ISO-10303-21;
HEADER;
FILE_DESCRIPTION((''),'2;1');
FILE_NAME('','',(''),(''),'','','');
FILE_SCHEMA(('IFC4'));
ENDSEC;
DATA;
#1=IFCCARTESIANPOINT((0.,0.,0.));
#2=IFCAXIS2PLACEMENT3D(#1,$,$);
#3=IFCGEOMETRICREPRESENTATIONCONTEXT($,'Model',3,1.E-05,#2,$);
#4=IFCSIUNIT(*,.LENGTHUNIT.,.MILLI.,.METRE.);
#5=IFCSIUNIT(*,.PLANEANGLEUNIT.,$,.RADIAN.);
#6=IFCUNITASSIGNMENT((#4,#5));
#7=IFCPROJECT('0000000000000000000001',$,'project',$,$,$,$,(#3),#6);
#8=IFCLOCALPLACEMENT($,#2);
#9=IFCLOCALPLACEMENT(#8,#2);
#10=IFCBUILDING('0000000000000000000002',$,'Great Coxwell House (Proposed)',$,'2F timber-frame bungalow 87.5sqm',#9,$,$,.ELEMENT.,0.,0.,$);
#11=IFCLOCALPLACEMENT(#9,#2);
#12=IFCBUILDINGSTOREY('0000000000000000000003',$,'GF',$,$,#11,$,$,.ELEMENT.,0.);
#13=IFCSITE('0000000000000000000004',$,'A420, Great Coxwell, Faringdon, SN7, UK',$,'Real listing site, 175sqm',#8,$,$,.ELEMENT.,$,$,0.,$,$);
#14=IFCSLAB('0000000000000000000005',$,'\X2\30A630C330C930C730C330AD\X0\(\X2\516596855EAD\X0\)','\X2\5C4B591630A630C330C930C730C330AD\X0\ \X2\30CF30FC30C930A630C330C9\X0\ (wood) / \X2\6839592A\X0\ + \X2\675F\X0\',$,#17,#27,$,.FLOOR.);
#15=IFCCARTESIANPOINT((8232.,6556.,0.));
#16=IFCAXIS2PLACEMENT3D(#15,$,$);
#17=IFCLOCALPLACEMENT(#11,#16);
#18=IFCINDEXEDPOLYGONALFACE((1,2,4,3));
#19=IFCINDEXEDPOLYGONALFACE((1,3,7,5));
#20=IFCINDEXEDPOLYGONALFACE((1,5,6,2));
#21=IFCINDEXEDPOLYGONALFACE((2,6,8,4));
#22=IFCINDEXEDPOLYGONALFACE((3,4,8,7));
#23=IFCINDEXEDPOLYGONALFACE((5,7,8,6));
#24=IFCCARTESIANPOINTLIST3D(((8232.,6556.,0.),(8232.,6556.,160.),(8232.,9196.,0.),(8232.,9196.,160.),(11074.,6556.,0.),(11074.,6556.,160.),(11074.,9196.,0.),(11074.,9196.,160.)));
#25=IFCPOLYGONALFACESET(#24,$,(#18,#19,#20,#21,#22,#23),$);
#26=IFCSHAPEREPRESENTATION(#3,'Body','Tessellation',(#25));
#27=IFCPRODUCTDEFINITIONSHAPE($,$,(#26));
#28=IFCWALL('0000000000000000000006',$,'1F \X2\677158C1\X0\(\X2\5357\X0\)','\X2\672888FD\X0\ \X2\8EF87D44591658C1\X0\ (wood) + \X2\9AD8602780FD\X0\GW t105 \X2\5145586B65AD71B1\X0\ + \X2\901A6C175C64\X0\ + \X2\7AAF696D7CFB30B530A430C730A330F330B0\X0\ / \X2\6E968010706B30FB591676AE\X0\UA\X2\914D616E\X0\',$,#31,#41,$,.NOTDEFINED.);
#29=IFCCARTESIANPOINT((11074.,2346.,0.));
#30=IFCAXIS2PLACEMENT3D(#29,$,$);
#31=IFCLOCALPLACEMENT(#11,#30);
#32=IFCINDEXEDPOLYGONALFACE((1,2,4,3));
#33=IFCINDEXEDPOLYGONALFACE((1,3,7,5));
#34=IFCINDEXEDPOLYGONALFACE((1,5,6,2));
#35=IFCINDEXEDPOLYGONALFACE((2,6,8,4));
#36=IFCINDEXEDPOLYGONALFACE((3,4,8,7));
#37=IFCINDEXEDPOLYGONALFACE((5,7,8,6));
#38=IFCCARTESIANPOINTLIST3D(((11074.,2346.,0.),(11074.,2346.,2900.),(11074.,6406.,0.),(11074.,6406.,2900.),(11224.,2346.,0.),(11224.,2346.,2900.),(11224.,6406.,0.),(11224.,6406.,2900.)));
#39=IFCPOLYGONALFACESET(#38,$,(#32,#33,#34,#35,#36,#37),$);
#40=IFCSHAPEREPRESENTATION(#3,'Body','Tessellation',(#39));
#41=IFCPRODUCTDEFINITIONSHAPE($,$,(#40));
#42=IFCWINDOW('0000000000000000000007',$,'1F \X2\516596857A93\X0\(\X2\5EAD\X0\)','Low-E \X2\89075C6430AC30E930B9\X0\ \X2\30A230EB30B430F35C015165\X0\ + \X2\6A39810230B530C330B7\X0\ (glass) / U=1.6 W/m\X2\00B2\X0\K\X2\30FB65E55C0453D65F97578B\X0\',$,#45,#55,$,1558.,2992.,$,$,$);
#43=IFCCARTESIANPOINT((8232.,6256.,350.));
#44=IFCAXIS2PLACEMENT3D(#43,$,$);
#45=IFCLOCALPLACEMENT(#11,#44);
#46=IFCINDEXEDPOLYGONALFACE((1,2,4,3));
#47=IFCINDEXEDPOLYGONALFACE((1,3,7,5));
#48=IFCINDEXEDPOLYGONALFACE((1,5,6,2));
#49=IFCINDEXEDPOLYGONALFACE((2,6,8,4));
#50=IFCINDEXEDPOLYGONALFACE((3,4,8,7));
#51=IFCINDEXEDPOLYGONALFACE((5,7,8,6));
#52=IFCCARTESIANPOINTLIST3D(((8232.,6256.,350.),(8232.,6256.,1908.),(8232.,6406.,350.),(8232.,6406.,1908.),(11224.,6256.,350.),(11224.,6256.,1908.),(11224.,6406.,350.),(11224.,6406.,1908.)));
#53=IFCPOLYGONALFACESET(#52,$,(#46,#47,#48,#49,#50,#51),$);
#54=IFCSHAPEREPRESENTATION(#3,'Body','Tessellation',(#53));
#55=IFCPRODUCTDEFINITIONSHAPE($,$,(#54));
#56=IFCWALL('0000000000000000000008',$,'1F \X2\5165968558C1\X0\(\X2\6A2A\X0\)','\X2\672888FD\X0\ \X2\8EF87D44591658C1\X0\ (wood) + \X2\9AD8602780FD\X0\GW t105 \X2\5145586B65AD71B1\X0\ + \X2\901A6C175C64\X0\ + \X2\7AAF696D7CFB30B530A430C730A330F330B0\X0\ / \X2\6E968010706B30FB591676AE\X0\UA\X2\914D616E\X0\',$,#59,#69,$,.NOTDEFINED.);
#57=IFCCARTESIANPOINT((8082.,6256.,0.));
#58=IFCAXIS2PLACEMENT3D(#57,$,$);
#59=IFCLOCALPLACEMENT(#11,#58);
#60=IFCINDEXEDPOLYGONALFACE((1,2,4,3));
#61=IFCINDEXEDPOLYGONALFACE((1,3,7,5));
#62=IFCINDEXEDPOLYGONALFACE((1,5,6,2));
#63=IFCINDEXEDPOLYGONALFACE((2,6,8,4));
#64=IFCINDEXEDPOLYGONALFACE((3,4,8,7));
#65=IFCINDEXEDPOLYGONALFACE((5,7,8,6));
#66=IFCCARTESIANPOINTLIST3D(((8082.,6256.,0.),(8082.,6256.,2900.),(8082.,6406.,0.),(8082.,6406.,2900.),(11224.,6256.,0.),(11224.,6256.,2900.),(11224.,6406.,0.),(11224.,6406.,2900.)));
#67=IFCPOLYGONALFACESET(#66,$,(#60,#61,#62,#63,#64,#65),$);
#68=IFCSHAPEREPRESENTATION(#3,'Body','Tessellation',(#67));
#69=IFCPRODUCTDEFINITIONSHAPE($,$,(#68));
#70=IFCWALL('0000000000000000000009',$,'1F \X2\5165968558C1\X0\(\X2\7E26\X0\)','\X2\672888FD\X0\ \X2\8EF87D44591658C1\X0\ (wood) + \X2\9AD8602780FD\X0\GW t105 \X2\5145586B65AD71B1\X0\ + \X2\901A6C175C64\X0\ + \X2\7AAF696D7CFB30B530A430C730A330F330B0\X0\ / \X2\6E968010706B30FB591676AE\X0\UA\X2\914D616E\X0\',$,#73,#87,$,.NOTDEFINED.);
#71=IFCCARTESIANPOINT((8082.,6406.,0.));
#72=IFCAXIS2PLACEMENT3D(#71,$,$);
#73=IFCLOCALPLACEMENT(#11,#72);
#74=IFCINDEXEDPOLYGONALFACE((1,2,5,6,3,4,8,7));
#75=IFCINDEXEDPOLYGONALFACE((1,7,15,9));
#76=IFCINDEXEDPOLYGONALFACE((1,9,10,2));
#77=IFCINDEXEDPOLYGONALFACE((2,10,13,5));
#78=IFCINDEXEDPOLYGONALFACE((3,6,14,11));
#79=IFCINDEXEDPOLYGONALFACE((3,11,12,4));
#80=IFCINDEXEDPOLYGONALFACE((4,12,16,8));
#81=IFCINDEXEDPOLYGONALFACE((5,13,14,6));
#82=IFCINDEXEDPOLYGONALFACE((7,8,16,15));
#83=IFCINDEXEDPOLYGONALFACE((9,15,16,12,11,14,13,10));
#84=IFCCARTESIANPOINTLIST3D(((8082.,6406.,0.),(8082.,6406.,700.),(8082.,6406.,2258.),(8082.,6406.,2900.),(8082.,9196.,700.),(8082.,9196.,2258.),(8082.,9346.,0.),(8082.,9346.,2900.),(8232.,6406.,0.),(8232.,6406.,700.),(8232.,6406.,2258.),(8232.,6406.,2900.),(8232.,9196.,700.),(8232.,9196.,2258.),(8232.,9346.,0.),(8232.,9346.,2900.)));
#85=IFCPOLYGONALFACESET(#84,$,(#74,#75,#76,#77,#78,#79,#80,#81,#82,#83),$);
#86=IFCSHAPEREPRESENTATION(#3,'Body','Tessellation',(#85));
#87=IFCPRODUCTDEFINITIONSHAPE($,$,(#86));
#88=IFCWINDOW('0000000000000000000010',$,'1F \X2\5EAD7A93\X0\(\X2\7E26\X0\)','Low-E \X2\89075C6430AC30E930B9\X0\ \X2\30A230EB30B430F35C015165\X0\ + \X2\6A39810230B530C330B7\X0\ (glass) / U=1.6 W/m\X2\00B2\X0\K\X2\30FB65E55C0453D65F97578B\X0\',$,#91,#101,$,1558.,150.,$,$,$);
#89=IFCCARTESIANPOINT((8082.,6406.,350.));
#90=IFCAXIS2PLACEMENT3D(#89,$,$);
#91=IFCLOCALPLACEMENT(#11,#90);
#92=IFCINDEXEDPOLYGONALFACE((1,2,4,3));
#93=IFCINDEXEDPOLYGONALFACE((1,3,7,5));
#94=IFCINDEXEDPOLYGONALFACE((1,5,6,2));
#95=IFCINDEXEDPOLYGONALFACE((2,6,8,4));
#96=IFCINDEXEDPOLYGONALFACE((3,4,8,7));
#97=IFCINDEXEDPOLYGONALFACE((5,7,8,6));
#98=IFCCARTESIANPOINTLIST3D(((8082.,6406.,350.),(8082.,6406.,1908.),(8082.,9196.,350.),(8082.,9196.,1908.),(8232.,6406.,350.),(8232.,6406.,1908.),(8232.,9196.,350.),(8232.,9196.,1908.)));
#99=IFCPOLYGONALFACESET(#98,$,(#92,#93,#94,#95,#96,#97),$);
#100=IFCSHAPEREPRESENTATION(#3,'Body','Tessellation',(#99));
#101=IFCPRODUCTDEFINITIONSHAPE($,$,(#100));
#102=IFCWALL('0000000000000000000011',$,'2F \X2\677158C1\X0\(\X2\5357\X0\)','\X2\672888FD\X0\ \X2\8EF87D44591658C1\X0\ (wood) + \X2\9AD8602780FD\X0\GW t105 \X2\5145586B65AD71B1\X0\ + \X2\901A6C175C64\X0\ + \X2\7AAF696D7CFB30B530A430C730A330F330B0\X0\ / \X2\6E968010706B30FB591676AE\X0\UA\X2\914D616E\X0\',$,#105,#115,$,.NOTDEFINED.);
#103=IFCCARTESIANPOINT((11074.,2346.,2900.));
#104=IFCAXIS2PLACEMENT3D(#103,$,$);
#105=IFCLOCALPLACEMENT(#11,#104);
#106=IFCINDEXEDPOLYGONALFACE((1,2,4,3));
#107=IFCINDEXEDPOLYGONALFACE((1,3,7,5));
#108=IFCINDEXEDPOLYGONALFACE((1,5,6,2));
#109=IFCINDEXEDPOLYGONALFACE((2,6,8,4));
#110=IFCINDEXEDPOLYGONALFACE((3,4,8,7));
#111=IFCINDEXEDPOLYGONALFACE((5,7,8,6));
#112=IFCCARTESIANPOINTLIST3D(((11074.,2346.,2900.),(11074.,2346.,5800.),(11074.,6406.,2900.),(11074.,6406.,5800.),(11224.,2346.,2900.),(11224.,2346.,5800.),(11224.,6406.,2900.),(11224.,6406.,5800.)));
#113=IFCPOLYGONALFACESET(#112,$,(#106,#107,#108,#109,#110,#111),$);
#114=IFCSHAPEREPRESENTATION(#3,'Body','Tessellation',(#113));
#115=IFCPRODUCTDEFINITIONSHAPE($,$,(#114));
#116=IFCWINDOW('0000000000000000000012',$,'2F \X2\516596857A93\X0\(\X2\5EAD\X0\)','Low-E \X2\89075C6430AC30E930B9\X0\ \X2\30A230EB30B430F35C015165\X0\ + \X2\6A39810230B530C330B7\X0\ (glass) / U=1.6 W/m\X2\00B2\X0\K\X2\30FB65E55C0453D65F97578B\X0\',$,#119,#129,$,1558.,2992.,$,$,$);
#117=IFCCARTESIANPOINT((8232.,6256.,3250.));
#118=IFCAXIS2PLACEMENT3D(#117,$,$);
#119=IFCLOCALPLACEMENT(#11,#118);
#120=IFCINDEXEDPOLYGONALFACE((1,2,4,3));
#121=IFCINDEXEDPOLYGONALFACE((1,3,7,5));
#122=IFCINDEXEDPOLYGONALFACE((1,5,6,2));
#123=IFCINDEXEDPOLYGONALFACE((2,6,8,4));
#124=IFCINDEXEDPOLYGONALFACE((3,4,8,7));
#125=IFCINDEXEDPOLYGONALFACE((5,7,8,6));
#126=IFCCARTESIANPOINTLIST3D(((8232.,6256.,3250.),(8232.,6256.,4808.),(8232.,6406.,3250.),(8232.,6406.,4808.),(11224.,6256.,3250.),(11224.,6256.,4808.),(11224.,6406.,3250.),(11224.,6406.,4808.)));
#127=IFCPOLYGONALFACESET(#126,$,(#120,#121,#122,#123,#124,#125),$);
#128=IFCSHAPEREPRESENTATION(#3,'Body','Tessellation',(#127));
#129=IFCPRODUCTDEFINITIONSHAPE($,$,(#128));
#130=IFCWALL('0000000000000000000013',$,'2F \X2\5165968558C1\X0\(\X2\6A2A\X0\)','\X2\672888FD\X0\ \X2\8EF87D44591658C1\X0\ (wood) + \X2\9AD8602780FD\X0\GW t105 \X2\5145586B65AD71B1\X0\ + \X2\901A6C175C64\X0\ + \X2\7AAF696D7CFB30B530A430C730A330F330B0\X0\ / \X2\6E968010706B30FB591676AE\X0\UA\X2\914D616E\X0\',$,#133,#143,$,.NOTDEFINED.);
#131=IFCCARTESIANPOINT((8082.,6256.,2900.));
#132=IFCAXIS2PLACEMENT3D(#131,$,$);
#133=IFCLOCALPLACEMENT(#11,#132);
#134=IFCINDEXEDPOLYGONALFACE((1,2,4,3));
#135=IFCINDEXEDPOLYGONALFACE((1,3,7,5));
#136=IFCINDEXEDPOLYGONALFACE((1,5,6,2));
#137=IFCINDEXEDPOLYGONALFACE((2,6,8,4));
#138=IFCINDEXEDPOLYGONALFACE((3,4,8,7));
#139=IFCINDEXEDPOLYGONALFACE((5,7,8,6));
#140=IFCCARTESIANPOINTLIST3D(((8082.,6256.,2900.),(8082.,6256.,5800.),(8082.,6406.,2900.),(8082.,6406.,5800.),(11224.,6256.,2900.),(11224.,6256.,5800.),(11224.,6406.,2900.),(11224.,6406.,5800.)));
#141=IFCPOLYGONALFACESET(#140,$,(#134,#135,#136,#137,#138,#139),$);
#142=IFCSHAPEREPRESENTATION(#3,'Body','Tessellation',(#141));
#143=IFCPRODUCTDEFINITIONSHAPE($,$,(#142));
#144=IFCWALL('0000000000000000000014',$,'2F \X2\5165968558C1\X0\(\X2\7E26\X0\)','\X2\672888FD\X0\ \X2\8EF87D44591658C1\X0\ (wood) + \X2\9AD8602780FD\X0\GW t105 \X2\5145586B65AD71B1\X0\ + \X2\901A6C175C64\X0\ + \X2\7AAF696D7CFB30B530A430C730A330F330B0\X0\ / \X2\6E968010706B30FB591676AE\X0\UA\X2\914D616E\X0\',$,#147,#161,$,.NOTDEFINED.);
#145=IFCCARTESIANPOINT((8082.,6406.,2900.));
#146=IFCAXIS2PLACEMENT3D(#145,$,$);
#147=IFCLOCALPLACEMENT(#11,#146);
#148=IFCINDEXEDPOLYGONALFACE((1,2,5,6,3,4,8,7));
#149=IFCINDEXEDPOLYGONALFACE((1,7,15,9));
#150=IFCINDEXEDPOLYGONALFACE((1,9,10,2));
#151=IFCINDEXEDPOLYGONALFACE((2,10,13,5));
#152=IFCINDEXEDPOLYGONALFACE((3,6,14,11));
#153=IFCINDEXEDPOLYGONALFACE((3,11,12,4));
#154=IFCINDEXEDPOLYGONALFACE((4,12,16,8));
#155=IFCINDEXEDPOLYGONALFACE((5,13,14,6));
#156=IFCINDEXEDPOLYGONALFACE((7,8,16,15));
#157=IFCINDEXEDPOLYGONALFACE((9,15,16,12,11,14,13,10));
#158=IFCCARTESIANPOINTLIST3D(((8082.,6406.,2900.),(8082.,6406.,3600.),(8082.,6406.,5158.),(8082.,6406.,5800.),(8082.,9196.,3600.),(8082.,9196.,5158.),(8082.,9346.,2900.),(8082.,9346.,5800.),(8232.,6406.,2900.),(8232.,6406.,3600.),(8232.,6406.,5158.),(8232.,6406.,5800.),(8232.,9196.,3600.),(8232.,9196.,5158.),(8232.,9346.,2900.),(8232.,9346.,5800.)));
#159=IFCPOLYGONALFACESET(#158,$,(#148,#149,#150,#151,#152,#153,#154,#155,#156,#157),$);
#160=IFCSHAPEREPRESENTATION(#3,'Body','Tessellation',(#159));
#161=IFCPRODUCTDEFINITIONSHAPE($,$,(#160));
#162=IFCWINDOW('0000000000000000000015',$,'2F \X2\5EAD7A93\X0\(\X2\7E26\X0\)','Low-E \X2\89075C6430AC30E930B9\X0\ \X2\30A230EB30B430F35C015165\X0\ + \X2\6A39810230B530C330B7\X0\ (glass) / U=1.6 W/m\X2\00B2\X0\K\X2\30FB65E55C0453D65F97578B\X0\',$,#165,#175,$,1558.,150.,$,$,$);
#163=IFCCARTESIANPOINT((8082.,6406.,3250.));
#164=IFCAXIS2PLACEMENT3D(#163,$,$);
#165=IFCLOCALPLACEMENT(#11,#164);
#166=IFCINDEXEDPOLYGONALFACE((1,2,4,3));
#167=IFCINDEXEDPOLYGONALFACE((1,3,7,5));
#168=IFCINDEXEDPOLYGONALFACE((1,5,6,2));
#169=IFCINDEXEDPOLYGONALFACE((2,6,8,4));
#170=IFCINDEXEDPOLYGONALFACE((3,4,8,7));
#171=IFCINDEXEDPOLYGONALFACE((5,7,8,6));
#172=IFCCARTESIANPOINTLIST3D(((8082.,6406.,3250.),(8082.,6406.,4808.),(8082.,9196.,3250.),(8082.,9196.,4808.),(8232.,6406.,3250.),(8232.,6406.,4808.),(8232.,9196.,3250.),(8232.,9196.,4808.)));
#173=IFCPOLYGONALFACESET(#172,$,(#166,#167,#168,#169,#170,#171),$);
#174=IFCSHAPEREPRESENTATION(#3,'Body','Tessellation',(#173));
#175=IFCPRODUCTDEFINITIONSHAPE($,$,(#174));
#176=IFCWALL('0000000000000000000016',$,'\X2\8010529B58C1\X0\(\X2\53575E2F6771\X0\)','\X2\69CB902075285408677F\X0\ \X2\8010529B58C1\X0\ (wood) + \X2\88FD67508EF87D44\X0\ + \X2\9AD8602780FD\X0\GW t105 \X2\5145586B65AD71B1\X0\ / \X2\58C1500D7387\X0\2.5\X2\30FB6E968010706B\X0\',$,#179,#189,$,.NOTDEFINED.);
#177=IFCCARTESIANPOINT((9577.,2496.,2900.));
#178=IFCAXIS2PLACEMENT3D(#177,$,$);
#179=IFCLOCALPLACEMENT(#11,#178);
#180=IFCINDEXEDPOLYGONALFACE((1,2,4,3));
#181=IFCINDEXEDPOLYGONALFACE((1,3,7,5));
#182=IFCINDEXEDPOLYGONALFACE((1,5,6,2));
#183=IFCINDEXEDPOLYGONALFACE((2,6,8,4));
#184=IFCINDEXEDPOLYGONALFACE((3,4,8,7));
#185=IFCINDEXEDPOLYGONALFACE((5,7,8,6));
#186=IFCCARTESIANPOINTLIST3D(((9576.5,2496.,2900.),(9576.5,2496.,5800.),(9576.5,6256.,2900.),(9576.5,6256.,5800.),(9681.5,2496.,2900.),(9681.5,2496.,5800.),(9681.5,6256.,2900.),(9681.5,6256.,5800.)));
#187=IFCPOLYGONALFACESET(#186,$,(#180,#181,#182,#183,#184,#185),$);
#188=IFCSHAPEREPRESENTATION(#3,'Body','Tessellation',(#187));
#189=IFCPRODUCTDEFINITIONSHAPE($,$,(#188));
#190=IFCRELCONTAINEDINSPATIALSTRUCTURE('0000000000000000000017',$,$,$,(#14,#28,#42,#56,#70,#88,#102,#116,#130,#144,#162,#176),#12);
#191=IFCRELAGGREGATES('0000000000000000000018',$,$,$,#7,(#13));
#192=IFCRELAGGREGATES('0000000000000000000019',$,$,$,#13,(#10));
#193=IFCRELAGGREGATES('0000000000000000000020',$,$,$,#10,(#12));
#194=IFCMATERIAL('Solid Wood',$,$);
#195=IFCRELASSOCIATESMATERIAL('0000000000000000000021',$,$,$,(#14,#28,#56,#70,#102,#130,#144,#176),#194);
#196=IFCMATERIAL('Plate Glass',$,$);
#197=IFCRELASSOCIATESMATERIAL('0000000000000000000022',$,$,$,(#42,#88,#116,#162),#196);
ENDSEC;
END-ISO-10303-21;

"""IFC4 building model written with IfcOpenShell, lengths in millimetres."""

from ifc_helpers import new_model, si_unit, frame, frame_2d, origin, place, context, project, spatial, rectangle, extrude, material, element, fill, save


model = new_model("IFC4")

# Units and contexts
model_context = context("Model", 3, precision=1e-05, world=origin())
ifc_project = project(units=[si_unit("LENGTHUNIT", "METRE", prefix="MILLI"), si_unit("PLANEANGLEUNIT", "RADIAN")], contexts=[model_context])

# Site, building, storey
site_placement = place(None, origin())
site = spatial("IfcSite", under=ifc_project, at=site_placement, Name="A420, Great Coxwell, Faringdon, SN7, UK", ObjectType="Real listing site, 175sqm", CompositionType="ELEMENT", RefElevation=0.0)
building_placement = place(site_placement, origin())
building = spatial("IfcBuilding", under=site, at=building_placement, Name="Great Coxwell House (Proposed)", ObjectType="2F timber-frame bungalow 87.5sqm", CompositionType="ELEMENT", ElevationOfRefHeight=0.0, ElevationOfTerrain=0.0)
storey_placement = place(building_placement, origin())
storey = spatial("IfcBuildingStorey", under=building, at=storey_placement, Name="GF", CompositionType="ELEMENT", Elevation=0.0)

# Slab
ifc_material_1 = material(Name="Solid Wood")
slab_placement = place(storey_placement, frame((8232.0, 6556.0, 0.0)))
element("IfcSlab", 1, at=slab_placement, inside=storey, material=ifc_material_1, Name="ウッドデッキ(入隅庭)", Description="屋外ウッドデッキ ハードウッド (wood) / 根太 + 束", PredefinedType="FLOOR", context=model_context, shape_type="SweptSolid", body=[
    extrude(rectangle(XDim=2842.0, YDim=2640.0, at=frame_2d((1421.0, 1320.0))), frame((8232.0, 6556.0, 0.0)), (0.0, 0.0, 1.0), 160.0),
])

# Wall, opening, window
wall_1_placement = place(storey_placement, frame((11074.0, 2346.0, 0.0)))
wall_1 = element("IfcWall", 2, at=wall_1_placement, inside=storey, material=ifc_material_1, Name="1F 東壁(南)", Description="木製 軸組外壁 (wood) + 高性能GW t105 充填断熱 + 通気層 + 窯業系サイディング / 準耐火・外皮UA配慮", PredefinedType="NOTDEFINED", context=model_context, shape_type="SweptSolid", body=[
    extrude(rectangle(XDim=150.0, YDim=4060.0, at=frame_2d((75.0, 2030.0))), frame((11074.0, 2346.0, 0.0)), (0.0, 0.0, 1.0), 2900.0),
])
opening_1_placement = place(storey_placement, frame((8232.0, 6256.0, 350.0)))
opening_1 = element("IfcOpeningElement", 3, at=opening_1_placement, cuts=wall_1, PredefinedType="NOTDEFINED", context=model_context, shape_type="SweptSolid", body=[
    extrude(rectangle(XDim=2992.0, YDim=150.0, at=frame_2d((1496.0, 75.0))), frame((8232.0, 6256.0, 350.0)), (0.0, 0.0, 1.0), 1558.0),
])
ifc_material_2 = material(Name="Plate Glass")
window_1_placement = place(storey_placement, frame((8232.0, 6256.0, 350.0)))
window_1 = element("IfcWindow", 4, at=window_1_placement, inside=storey, material=ifc_material_2, Name="1F 入隅窓(庭)", Description="Low-E 複層ガラス アルゴン封入 + 樹脂サッシ (glass) / U=1.6 W/m²K・日射取得型", OverallHeight=1558.0, OverallWidth=2992.0, context=model_context, shape_type="SweptSolid", body=[
    extrude(rectangle(XDim=2992.0, YDim=150.0, at=frame_2d((1496.0, 75.0))), frame((8232.0, 6256.0, 350.0)), (0.0, 0.0, 1.0), 1558.0),
])
fill(opening_1, window_1)

# Wall
wall_2_placement = place(storey_placement, frame((8082.0, 6256.0, 0.0)))
element("IfcWall", 5, at=wall_2_placement, inside=storey, material=ifc_material_1, Name="1F 入隅壁(横)", Description="木製 軸組外壁 (wood) + 高性能GW t105 充填断熱 + 通気層 + 窯業系サイディング / 準耐火・外皮UA配慮", PredefinedType="NOTDEFINED", context=model_context, shape_type="SweptSolid", body=[
    extrude(rectangle(XDim=3142.0, YDim=150.0, at=frame_2d((1571.0, 75.0))), frame((8082.0, 6256.0, 0.0)), (0.0, 0.0, 1.0), 2900.0),
])

# Wall, opening, window
wall_3_placement = place(storey_placement, frame((8082.0, 6406.0, 0.0)))
wall_3 = element("IfcWall", 6, at=wall_3_placement, inside=storey, material=ifc_material_1, Name="1F 入隅壁(縦)", Description="木製 軸組外壁 (wood) + 高性能GW t105 充填断熱 + 通気層 + 窯業系サイディング / 準耐火・外皮UA配慮", PredefinedType="NOTDEFINED", context=model_context, shape_type="SweptSolid", body=[
    extrude(rectangle(XDim=150.0, YDim=2940.0, at=frame_2d((75.0, 1470.0))), frame((8082.0, 6406.0, 0.0)), (0.0, 0.0, 1.0), 2900.0),
])
opening_2_placement = place(storey_placement, frame((8082.0, 6406.0, 350.0)))
opening_2 = element("IfcOpeningElement", 7, at=opening_2_placement, cuts=wall_3, PredefinedType="NOTDEFINED", context=model_context, shape_type="SweptSolid", body=[
    extrude(rectangle(XDim=150.0, YDim=2790.0, at=frame_2d((75.0, 1395.0))), frame((8082.0, 6406.0, 350.0)), (0.0, 0.0, 1.0), 1558.0),
])
window_2_placement = place(storey_placement, frame((8082.0, 6406.0, 350.0)))
window_2 = element("IfcWindow", 8, at=window_2_placement, inside=storey, material=ifc_material_2, Name="1F 庭窓(縦)", Description="Low-E 複層ガラス アルゴン封入 + 樹脂サッシ (glass) / U=1.6 W/m²K・日射取得型", OverallHeight=1558.0, OverallWidth=150.0, context=model_context, shape_type="SweptSolid", body=[
    extrude(rectangle(XDim=150.0, YDim=2790.0, at=frame_2d((75.0, 1395.0))), frame((8082.0, 6406.0, 350.0)), (0.0, 0.0, 1.0), 1558.0),
])
fill(opening_2, window_2)

# Wall, opening, window
wall_4_placement = place(storey_placement, frame((11074.0, 2346.0, 2900.0)))
wall_4 = element("IfcWall", 9, at=wall_4_placement, inside=storey, material=ifc_material_1, Name="2F 東壁(南)", Description="木製 軸組外壁 (wood) + 高性能GW t105 充填断熱 + 通気層 + 窯業系サイディング / 準耐火・外皮UA配慮", PredefinedType="NOTDEFINED", context=model_context, shape_type="SweptSolid", body=[
    extrude(rectangle(XDim=150.0, YDim=4060.0, at=frame_2d((75.0, 2030.0))), frame((11074.0, 2346.0, 2900.0)), (0.0, 0.0, 1.0), 2900.0),
])
opening_3_placement = place(storey_placement, frame((8232.0, 6256.0, 3250.0)))
opening_3 = element("IfcOpeningElement", 10, at=opening_3_placement, cuts=wall_4, PredefinedType="NOTDEFINED", context=model_context, shape_type="SweptSolid", body=[
    extrude(rectangle(XDim=2992.0, YDim=150.0, at=frame_2d((1496.0, 75.0))), frame((8232.0, 6256.0, 3250.0)), (0.0, 0.0, 1.0), 1558.0),
])
window_3_placement = place(storey_placement, frame((8232.0, 6256.0, 3250.0)))
window_3 = element("IfcWindow", 11, at=window_3_placement, inside=storey, material=ifc_material_2, Name="2F 入隅窓(庭)", Description="Low-E 複層ガラス アルゴン封入 + 樹脂サッシ (glass) / U=1.6 W/m²K・日射取得型", OverallHeight=1558.0, OverallWidth=2992.0, context=model_context, shape_type="SweptSolid", body=[
    extrude(rectangle(XDim=2992.0, YDim=150.0, at=frame_2d((1496.0, 75.0))), frame((8232.0, 6256.0, 3250.0)), (0.0, 0.0, 1.0), 1558.0),
])
fill(opening_3, window_3)

# Wall
wall_5_placement = place(storey_placement, frame((8082.0, 6256.0, 2900.0)))
element("IfcWall", 12, at=wall_5_placement, inside=storey, material=ifc_material_1, Name="2F 入隅壁(横)", Description="木製 軸組外壁 (wood) + 高性能GW t105 充填断熱 + 通気層 + 窯業系サイディング / 準耐火・外皮UA配慮", PredefinedType="NOTDEFINED", context=model_context, shape_type="SweptSolid", body=[
    extrude(rectangle(XDim=3142.0, YDim=150.0, at=frame_2d((1571.0, 75.0))), frame((8082.0, 6256.0, 2900.0)), (0.0, 0.0, 1.0), 2900.0),
])

# Wall, opening, window
wall_6_placement = place(storey_placement, frame((8082.0, 6406.0, 2900.0)))
wall_6 = element("IfcWall", 13, at=wall_6_placement, inside=storey, material=ifc_material_1, Name="2F 入隅壁(縦)", Description="木製 軸組外壁 (wood) + 高性能GW t105 充填断熱 + 通気層 + 窯業系サイディング / 準耐火・外皮UA配慮", PredefinedType="NOTDEFINED", context=model_context, shape_type="SweptSolid", body=[
    extrude(rectangle(XDim=150.0, YDim=2940.0, at=frame_2d((75.0, 1470.0))), frame((8082.0, 6406.0, 2900.0)), (0.0, 0.0, 1.0), 2900.0),
])
opening_4_placement = place(storey_placement, frame((8082.0, 6406.0, 3250.0)))
opening_4 = element("IfcOpeningElement", 14, at=opening_4_placement, cuts=wall_6, PredefinedType="NOTDEFINED", context=model_context, shape_type="SweptSolid", body=[
    extrude(rectangle(XDim=150.0, YDim=2790.0, at=frame_2d((75.0, 1395.0))), frame((8082.0, 6406.0, 3250.0)), (0.0, 0.0, 1.0), 1558.0),
])
window_4_placement = place(storey_placement, frame((8082.0, 6406.0, 3250.0)))
window_4 = element("IfcWindow", 15, at=window_4_placement, inside=storey, material=ifc_material_2, Name="2F 庭窓(縦)", Description="Low-E 複層ガラス アルゴン封入 + 樹脂サッシ (glass) / U=1.6 W/m²K・日射取得型", OverallHeight=1558.0, OverallWidth=150.0, context=model_context, shape_type="SweptSolid", body=[
    extrude(rectangle(XDim=150.0, YDim=2790.0, at=frame_2d((75.0, 1395.0))), frame((8082.0, 6406.0, 3250.0)), (0.0, 0.0, 1.0), 1558.0),
])
fill(opening_4, window_4)

# Wall
wall_7_placement = place(storey_placement, frame((9577.0, 2496.0, 2900.0)))
element("IfcWall", 16, at=wall_7_placement, inside=storey, material=ifc_material_1, Name="耐力壁(南帯東)", Description="構造用合板 耐力壁 (wood) + 製材軸組 + 高性能GW t105 充填断熱 / 壁倍率2.5・準耐火", PredefinedType="NOTDEFINED", context=model_context, shape_type="SweptSolid", body=[
    extrude(rectangle(XDim=105.0, YDim=3760.0, at=frame_2d((52.0, 1880.0))), frame((9577.0, 2496.0, 2900.0)), (0.0, 0.0, 1.0), 2900.0),
])

save(model, "model.ifc")
